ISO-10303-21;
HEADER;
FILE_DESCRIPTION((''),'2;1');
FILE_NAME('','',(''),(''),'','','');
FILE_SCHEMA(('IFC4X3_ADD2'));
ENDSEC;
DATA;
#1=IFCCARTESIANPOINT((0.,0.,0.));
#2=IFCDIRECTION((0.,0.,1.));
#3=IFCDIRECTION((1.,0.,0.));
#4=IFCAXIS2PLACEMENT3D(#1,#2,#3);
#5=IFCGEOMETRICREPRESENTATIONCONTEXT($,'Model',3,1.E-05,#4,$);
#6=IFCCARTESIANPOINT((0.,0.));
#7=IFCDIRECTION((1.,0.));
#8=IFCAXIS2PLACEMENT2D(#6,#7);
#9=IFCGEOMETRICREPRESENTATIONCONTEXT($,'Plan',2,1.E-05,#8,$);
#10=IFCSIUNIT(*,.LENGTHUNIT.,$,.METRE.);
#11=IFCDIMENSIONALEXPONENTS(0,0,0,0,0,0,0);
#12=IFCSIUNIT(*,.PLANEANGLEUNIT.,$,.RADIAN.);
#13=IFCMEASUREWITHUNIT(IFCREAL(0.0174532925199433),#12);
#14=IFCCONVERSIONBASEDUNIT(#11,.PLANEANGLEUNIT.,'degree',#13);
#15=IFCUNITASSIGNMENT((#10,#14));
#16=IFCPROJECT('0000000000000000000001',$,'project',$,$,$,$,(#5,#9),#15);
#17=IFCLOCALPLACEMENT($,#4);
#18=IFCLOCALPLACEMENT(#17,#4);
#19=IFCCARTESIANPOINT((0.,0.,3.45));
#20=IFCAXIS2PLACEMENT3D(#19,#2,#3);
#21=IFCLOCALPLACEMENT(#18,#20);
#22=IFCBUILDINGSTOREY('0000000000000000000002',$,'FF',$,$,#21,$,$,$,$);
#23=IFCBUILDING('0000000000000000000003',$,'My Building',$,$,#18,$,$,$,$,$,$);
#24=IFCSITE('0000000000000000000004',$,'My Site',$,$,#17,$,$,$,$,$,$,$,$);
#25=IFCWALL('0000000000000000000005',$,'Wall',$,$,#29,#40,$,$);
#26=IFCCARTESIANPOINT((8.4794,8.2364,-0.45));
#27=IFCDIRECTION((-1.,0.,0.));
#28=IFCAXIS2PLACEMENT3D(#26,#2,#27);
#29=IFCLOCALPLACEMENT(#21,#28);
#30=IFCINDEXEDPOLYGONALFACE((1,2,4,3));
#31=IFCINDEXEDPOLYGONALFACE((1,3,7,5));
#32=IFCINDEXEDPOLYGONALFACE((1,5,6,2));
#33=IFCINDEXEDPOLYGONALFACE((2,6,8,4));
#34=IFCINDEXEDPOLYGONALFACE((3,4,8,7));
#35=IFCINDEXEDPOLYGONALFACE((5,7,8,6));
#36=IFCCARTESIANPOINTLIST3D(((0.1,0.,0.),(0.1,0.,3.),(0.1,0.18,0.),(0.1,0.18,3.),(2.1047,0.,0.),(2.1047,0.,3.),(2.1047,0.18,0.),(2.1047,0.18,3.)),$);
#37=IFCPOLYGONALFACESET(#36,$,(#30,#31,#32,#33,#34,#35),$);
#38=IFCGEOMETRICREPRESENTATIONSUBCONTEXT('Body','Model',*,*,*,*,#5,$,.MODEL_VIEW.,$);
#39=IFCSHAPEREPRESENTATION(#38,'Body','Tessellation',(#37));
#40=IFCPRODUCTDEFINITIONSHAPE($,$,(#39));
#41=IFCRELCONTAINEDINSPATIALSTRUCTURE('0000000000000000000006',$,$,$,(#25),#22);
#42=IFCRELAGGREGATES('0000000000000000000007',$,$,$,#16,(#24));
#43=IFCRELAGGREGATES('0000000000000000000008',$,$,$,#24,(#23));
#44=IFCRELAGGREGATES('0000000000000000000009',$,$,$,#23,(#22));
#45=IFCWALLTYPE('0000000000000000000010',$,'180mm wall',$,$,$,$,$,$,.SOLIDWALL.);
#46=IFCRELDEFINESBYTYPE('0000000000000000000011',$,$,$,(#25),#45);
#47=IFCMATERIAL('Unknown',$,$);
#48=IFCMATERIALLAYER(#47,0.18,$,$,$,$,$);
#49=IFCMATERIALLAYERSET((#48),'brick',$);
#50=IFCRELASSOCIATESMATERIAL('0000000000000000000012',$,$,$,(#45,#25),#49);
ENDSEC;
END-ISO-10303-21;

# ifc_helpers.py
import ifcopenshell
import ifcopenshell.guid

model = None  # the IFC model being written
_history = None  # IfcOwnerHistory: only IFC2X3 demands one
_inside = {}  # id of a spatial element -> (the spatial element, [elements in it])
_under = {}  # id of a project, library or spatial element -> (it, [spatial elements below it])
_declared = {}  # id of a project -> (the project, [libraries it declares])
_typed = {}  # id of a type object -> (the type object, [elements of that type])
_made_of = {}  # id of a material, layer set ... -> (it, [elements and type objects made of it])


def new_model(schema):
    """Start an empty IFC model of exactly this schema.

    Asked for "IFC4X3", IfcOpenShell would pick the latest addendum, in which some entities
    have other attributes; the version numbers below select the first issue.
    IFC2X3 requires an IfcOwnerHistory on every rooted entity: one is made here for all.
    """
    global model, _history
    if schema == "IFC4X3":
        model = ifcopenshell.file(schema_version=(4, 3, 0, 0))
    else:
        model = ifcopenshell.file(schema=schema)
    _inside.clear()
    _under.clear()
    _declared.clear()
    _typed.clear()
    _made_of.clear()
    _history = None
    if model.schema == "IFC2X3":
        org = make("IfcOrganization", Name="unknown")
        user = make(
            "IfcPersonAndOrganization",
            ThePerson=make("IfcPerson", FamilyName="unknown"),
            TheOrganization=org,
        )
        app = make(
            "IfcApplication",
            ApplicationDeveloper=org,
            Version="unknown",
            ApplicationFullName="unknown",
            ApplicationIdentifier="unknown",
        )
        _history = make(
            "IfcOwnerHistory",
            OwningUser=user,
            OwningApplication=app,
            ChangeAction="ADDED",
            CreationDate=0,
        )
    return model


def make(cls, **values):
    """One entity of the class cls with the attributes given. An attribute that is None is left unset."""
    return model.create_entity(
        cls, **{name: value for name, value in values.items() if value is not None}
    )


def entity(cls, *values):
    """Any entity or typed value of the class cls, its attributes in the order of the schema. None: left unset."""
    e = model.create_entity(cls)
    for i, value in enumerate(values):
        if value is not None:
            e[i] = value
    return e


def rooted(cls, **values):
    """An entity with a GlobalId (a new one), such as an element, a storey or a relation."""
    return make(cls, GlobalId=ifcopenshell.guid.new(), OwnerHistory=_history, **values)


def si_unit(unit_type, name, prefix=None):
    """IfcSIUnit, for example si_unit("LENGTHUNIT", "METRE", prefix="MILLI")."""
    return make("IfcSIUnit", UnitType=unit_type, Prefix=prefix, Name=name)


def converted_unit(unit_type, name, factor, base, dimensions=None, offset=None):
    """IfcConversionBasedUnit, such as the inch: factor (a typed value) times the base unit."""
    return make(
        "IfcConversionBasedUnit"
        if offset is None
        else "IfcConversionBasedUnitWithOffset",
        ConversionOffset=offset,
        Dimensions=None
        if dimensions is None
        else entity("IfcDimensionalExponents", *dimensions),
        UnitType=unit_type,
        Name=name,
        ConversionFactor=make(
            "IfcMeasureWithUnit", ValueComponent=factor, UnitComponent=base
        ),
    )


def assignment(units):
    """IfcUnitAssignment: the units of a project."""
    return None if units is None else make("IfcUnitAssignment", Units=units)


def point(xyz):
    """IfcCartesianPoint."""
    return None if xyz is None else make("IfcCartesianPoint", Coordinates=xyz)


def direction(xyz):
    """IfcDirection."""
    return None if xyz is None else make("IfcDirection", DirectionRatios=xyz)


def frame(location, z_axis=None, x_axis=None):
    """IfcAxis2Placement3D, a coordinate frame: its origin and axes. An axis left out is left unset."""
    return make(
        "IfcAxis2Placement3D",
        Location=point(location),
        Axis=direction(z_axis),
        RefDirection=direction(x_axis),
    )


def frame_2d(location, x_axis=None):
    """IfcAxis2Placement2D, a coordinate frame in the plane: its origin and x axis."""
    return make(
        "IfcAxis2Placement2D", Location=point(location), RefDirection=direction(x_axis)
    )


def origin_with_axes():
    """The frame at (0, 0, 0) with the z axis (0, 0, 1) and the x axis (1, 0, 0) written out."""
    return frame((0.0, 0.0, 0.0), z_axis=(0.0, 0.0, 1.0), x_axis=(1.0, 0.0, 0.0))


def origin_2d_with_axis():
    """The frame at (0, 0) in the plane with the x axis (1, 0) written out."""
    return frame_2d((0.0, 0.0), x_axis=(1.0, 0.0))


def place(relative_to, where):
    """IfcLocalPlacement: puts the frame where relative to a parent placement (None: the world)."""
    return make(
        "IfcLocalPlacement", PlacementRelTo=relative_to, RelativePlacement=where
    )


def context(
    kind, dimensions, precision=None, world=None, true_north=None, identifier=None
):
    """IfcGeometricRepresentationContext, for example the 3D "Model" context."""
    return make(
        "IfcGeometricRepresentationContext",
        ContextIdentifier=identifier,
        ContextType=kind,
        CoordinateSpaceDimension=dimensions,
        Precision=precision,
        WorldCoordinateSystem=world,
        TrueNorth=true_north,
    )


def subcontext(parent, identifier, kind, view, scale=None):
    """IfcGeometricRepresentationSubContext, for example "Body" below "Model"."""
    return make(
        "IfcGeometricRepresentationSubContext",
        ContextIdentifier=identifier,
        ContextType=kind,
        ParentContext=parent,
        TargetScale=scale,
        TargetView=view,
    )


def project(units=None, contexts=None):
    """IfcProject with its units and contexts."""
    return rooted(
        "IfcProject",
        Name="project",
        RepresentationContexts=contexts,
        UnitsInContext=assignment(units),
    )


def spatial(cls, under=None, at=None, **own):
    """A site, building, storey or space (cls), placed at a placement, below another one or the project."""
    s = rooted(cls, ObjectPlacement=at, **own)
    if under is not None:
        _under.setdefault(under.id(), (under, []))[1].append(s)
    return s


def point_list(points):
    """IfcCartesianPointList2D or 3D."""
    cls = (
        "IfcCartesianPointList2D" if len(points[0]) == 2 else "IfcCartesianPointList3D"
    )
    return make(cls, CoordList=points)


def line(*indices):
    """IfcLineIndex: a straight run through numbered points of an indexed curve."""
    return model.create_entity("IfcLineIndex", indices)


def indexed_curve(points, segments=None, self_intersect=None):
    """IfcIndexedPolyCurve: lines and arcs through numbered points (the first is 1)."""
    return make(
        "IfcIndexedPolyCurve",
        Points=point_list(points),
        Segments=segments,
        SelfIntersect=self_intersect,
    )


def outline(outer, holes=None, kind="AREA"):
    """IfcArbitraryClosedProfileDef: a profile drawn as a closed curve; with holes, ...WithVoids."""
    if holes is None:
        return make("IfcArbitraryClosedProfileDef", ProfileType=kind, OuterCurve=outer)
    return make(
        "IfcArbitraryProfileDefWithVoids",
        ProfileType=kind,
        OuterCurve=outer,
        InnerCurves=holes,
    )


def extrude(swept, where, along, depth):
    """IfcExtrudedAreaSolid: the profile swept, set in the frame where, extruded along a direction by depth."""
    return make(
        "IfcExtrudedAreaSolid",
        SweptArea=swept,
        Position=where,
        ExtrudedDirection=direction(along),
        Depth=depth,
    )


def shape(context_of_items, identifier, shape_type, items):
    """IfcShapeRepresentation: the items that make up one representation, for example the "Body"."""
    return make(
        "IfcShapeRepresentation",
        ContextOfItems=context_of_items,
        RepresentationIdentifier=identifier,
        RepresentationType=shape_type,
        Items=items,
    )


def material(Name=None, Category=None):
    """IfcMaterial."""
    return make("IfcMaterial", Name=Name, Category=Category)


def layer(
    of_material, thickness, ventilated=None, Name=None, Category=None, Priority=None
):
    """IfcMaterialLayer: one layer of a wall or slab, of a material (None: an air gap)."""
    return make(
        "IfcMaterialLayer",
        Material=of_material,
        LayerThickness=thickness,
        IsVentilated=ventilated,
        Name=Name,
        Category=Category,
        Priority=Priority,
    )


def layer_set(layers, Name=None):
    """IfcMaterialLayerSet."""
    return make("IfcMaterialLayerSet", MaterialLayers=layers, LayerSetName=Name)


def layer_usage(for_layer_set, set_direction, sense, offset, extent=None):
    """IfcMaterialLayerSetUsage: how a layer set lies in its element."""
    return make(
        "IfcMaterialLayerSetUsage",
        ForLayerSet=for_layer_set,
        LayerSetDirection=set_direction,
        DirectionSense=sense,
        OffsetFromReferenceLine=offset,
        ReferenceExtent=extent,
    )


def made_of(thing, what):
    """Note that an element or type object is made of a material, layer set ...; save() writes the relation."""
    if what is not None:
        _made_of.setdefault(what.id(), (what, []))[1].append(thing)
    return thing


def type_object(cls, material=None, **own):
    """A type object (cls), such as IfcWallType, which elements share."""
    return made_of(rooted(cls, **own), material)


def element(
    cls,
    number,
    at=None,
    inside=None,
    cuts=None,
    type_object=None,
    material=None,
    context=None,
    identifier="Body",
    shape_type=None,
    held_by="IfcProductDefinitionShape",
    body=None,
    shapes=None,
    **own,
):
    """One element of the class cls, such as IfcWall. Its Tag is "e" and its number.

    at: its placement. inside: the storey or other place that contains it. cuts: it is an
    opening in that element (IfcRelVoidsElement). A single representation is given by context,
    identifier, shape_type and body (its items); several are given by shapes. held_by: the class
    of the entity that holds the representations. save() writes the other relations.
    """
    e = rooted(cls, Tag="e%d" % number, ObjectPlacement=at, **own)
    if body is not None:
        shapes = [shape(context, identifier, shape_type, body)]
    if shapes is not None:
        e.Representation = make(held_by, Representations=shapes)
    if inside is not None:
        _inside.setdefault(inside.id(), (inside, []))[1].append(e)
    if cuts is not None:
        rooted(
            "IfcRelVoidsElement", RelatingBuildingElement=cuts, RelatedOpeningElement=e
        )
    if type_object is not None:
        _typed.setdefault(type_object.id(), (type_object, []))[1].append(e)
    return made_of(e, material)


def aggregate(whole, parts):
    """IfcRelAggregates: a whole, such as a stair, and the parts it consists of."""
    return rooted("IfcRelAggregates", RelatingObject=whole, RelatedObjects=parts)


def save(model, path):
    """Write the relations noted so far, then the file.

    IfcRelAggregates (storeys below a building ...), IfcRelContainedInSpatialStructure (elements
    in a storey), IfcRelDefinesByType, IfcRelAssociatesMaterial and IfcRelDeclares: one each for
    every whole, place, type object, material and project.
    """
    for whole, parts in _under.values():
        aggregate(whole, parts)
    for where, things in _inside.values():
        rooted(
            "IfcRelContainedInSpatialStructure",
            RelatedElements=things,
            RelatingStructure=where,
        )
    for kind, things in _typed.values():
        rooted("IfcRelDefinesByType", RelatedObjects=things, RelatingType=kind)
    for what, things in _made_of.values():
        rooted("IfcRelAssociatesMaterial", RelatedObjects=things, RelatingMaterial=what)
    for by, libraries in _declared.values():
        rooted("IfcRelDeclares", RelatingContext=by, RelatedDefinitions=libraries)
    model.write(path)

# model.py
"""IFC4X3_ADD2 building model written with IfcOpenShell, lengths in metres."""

from ifc_helpers import new_model, entity, si_unit, converted_unit, frame, origin_with_axes, origin_2d_with_axis, place, context, subcontext, project, spatial, line, indexed_curve, outline, extrude, material, layer, layer_set, layer_usage, type_object, element, save


model = new_model("IFC4X3_ADD2")

# Units and contexts
model_context = context("Model", 3, precision=1e-05, world=origin_with_axes())
plan_context = context("Plan", 2, precision=1e-05, world=origin_2d_with_axis())
body_context_1 = subcontext(model_context, "Body", "Model", "MODEL_VIEW")
ifc_project = project(units=[si_unit("LENGTHUNIT", "METRE"), converted_unit("PLANEANGLEUNIT", "degree", entity("IfcReal", 0.0174532925199433), si_unit("PLANEANGLEUNIT", "RADIAN"), dimensions=[0, 0, 0, 0, 0, 0, 0])], contexts=[model_context, plan_context])

# Site, building, storey
site_placement = place(None, origin_with_axes())
site = spatial("IfcSite", under=ifc_project, at=site_placement, Name="My Site")
building_placement = place(site_placement, origin_with_axes())
building = spatial("IfcBuilding", under=site, at=building_placement, Name="My Building")
storey_placement = place(building_placement, frame((0.0, 0.0, 3.45), z_axis=(0.0, 0.0, 1.0), x_axis=(1.0, 0.0, 0.0)))
storey = spatial("IfcBuildingStorey", under=building, at=storey_placement, Name="FF")

# Wall
ifc_material_1 = material(Name="Unknown")
ifc_layer_1 = layer(ifc_material_1, 0.18)
ifc_layer_set_1 = layer_set([ifc_layer_1], Name="brick")
ifc_layer_usage_1 = layer_usage(ifc_layer_set_1, "AXIS2", "POSITIVE", 0.0)
wall_type_1 = type_object("IfcWallType", Name="180mm wall", PredefinedType="SOLIDWALL", material=ifc_layer_set_1)
wall_1_placement = place(storey_placement, frame((8.4794, 8.2364, -0.45), z_axis=(0.0, 0.0, 1.0), x_axis=(-1.0, 0.0, 0.0)))
element("IfcWall", 1, at=wall_1_placement, inside=storey, type_object=wall_type_1, material=ifc_layer_usage_1, Name="Wall", context=body_context_1, shape_type="SweptSolid", body=[
    extrude(outline(indexed_curve([(0.1, 0.0), (0.1, 0.18), (2.1047, 0.18), (2.1047, 0.0)], segments=[line(1, 2, 3, 4, 1)])), origin_with_axes(), (0.0, 0.0, 1.0), 3.0),
])

save(model, "model.ifc")
